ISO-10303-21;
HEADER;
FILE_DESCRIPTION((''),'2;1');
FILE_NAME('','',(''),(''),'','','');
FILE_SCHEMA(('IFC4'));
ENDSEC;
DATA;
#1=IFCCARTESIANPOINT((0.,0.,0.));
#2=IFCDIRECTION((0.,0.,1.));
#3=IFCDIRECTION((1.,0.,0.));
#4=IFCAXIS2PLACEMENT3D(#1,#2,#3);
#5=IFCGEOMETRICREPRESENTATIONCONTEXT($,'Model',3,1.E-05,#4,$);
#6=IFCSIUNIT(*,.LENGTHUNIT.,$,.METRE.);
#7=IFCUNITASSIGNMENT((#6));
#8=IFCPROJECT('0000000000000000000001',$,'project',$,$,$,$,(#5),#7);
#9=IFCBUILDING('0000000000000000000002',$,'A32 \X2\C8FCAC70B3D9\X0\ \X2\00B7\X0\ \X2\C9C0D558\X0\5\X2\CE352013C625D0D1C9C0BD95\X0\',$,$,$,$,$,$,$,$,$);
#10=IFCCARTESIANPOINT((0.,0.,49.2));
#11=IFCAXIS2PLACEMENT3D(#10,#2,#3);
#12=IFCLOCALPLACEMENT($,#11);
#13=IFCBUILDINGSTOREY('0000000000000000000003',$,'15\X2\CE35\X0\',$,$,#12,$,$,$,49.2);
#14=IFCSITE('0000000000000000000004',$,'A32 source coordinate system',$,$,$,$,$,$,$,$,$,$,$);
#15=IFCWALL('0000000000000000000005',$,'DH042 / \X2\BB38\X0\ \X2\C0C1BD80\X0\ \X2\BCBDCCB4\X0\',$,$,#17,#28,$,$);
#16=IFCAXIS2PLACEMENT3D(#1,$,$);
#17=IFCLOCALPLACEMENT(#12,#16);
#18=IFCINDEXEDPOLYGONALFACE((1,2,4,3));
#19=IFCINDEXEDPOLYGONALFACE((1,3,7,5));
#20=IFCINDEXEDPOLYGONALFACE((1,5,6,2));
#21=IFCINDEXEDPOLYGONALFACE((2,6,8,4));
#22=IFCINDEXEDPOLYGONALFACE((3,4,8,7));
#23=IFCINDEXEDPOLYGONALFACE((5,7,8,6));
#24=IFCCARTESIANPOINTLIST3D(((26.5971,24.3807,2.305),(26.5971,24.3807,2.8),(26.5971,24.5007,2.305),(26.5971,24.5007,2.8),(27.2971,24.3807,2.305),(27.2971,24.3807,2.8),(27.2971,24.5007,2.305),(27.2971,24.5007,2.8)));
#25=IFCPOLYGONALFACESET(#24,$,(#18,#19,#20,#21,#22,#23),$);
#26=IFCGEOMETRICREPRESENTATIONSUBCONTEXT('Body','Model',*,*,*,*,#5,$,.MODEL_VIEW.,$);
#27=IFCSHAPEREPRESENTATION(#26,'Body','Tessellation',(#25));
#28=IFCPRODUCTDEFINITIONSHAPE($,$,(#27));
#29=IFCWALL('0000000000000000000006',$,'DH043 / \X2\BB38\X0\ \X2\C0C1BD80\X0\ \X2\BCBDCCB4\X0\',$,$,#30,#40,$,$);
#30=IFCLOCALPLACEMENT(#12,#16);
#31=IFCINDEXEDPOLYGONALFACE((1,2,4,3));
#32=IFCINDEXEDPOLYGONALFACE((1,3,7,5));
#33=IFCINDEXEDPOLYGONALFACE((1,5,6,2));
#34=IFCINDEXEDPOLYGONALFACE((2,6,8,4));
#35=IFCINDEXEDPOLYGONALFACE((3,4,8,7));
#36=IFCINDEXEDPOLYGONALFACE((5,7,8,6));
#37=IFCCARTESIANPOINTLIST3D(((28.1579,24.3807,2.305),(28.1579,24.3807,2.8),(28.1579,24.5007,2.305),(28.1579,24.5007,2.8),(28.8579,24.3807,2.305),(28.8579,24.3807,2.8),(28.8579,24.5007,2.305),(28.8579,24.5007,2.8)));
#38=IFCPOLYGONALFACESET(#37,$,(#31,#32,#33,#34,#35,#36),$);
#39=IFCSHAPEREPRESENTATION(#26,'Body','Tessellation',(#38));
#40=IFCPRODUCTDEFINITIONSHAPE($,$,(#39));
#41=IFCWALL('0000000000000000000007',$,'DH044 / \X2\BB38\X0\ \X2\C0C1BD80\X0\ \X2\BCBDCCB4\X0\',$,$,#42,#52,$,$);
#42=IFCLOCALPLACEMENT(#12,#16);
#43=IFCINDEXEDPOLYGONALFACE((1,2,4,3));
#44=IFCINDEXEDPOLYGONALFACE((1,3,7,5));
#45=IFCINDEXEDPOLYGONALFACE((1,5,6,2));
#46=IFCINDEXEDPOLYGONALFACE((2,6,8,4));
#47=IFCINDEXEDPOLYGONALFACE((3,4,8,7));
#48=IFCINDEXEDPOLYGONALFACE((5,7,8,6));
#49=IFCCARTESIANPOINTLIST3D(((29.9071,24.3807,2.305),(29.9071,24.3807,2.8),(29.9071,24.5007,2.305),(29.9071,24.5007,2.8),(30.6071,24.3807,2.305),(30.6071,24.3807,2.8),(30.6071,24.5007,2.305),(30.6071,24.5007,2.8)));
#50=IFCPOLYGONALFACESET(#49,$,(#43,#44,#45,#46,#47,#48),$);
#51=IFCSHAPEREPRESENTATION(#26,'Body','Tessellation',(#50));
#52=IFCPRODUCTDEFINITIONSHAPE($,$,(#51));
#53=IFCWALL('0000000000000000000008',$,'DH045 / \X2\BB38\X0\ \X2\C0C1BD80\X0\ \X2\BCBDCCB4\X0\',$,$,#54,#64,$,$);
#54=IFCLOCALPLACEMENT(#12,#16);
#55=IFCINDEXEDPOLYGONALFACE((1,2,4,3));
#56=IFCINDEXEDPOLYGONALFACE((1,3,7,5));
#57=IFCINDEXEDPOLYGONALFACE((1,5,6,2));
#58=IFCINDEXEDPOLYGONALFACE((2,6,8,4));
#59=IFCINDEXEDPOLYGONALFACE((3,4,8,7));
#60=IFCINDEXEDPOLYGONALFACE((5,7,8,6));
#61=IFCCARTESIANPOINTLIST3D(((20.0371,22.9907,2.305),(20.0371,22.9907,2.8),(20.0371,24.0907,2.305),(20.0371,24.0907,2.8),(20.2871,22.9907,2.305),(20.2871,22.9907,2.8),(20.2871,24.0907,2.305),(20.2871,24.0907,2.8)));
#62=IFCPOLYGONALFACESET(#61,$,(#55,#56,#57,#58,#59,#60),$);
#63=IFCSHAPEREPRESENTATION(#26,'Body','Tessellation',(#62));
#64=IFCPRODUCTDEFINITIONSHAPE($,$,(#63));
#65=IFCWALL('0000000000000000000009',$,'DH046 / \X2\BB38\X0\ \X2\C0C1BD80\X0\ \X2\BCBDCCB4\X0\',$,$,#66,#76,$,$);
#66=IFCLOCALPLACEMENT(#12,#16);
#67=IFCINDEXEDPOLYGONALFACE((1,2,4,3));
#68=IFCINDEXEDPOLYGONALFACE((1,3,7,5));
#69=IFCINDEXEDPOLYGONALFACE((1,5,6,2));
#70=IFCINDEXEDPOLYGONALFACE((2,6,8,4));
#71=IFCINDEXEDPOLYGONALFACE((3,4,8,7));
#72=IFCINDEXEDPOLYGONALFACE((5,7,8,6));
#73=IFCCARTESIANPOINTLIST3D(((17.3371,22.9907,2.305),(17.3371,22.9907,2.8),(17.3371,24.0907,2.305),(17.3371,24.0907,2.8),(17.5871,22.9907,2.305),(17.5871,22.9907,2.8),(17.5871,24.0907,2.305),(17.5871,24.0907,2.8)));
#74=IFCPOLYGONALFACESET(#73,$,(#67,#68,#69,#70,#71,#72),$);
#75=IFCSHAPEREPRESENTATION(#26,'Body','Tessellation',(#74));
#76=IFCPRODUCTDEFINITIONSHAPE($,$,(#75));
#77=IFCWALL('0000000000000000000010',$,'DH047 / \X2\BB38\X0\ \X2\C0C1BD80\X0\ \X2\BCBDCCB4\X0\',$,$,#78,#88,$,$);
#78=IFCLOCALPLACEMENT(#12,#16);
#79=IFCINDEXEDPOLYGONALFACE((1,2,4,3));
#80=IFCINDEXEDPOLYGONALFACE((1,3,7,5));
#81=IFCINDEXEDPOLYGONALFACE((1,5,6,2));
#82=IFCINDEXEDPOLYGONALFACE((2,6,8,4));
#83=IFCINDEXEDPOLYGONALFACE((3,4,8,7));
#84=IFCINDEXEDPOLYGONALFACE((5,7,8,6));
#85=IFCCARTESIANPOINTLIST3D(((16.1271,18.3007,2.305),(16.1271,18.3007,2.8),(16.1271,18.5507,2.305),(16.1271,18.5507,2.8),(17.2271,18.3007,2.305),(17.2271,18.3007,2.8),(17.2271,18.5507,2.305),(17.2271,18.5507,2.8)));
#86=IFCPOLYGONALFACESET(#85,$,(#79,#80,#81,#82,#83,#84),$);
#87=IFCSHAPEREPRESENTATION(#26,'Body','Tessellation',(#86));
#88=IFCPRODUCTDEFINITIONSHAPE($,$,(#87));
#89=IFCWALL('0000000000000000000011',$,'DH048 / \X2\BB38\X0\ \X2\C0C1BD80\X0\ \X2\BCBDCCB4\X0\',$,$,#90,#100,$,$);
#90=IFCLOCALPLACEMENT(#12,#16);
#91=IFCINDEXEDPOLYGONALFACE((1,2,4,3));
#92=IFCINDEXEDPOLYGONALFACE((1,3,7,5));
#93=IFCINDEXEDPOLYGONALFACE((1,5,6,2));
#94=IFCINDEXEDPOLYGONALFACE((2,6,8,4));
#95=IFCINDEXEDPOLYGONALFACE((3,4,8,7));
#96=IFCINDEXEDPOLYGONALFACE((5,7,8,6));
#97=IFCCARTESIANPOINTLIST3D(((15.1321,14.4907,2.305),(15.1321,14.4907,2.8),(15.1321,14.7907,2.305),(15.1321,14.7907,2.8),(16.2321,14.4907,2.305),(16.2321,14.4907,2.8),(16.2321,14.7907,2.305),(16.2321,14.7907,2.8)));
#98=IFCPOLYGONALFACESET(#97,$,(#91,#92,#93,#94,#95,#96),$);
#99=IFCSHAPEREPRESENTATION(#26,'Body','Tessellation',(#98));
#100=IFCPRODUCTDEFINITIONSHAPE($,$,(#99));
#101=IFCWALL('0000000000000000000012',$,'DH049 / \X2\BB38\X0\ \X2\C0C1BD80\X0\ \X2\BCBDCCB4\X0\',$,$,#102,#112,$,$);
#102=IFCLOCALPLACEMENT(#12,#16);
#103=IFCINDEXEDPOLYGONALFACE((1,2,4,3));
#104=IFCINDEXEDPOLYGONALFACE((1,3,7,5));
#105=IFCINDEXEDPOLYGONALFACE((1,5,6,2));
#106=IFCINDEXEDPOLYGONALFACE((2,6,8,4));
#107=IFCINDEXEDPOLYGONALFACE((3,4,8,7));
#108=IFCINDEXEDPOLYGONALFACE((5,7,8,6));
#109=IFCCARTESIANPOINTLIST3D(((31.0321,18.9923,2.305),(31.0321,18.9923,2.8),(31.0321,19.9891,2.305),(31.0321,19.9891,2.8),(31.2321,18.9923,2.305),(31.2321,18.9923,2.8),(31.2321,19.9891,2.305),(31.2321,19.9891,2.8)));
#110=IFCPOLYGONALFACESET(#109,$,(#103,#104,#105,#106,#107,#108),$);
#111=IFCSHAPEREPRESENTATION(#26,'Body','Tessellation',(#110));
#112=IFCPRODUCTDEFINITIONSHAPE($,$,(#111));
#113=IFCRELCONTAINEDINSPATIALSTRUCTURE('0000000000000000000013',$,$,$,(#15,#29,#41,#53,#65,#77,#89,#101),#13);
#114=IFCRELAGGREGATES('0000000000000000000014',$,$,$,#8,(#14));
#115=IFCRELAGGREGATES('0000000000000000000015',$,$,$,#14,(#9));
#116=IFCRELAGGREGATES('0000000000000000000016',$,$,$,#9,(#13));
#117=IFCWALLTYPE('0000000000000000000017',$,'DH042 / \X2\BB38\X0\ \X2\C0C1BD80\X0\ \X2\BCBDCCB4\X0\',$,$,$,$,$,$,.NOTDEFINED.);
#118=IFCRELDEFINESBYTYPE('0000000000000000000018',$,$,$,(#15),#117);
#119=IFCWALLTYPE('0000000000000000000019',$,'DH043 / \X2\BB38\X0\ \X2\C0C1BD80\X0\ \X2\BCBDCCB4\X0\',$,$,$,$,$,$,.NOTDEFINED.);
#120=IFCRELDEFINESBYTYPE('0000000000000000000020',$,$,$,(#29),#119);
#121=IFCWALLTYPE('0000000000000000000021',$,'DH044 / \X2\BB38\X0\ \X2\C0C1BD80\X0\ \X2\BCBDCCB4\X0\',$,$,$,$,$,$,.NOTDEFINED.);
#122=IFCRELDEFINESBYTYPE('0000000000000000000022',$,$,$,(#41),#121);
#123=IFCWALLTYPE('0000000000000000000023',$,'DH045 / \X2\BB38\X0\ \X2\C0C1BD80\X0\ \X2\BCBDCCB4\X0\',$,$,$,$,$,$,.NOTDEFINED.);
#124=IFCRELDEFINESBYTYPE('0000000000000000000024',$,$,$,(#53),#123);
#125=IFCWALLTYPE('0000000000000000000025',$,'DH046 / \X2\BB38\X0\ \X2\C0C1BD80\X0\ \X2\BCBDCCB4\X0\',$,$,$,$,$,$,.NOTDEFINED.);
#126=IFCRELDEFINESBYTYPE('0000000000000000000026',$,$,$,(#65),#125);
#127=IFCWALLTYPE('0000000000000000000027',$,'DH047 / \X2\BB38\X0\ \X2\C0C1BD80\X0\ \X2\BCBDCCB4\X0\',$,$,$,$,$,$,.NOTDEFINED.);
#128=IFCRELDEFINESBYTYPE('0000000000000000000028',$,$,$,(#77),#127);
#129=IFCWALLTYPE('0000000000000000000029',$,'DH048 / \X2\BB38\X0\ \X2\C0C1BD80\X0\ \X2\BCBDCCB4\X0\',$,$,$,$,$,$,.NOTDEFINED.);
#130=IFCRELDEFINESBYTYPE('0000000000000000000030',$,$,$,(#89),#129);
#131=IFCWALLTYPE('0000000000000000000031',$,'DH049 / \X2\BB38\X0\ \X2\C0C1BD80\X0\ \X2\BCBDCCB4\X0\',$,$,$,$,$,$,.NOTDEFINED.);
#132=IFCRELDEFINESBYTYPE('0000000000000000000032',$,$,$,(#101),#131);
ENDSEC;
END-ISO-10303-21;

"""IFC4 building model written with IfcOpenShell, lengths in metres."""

from ifc_helpers import new_model, si_unit, frame, origin, origin_with_axes, place, context, subcontext, project, spatial, polyline, outline, extrude, source, transform, mapped, type_object, type_shapes, element, save


model = new_model("IFC4")

# Units and contexts
model_context = context("Model", 3, precision=1e-05, world=origin_with_axes())
body_context = subcontext(model_context, "Body", "Model", "MODEL_VIEW")
ifc_project = project(units=[si_unit("LENGTHUNIT", "METRE")], contexts=[model_context])

# Site, building, storey
site = spatial("IfcSite", under=ifc_project, Name="A32 source coordinate system")
building = spatial("IfcBuilding", under=site, Name="A32 주거동 · 지하5층–옥탑지붕")
storey_placement = place(None, frame((0.0, 0.0, 49.2), z_axis=(0.0, 0.0, 1.0), x_axis=(1.0, 0.0, 0.0)))
storey = spatial("IfcBuildingStorey", under=building, at=storey_placement, Name="15층", Elevation=49.2)

# Walls
wall_type_1 = type_object("IfcWallType", Name="DH042 / 문 상부 벽체", PredefinedType="NOTDEFINED")
shared_shape_1 = source(origin(), body_context, "Body", "SweptSolid", [
    extrude(outline(polyline([(27.2971, 24.3807), (26.5971, 24.3807), (26.5971, 24.5007), (27.2971, 24.5007), (27.2971, 24.3807)])), frame((0.0, 0.0, 2.305)), (0.0, 0.0, 1.0), 0.495),
])
type_shapes(wall_type_1, [shared_shape_1])
wall_1_placement = place(storey_placement, origin_with_axes())
element("IfcWall", 1, at=wall_1_placement, inside=storey, type_object=wall_type_1, Name="DH042 / 문 상부 벽체", context=body_context, shape_type="MappedRepresentation", body=[
    mapped(shared_shape_1, transform((0.0, 0.0, 0.0), scale=1.0)),
])
wall_type_2 = type_object("IfcWallType", Name="DH043 / 문 상부 벽체", PredefinedType="NOTDEFINED")
shared_shape_2 = source(origin(), body_context, "Body", "SweptSolid", [
    extrude(outline(polyline([(28.8579, 24.3807), (28.1579, 24.3807), (28.1579, 24.5007), (28.8579, 24.5007), (28.8579, 24.3807)])), frame((0.0, 0.0, 2.305)), (0.0, 0.0, 1.0), 0.495),
])
type_shapes(wall_type_2, [shared_shape_2])
wall_2_placement = place(storey_placement, origin_with_axes())
element("IfcWall", 2, at=wall_2_placement, inside=storey, type_object=wall_type_2, Name="DH043 / 문 상부 벽체", context=body_context, shape_type="MappedRepresentation", body=[
    mapped(shared_shape_2, transform((0.0, 0.0, 0.0), scale=1.0)),
])
wall_type_3 = type_object("IfcWallType", Name="DH044 / 문 상부 벽체", PredefinedType="NOTDEFINED")
shared_shape_3 = source(origin(), body_context, "Body", "SweptSolid", [
    extrude(outline(polyline([(30.6071, 24.3807), (29.9071, 24.3807), (29.9071, 24.5007), (30.6071, 24.5007), (30.6071, 24.3807)])), frame((0.0, 0.0, 2.305)), (0.0, 0.0, 1.0), 0.495),
])
type_shapes(wall_type_3, [shared_shape_3])
wall_3_placement = place(storey_placement, origin_with_axes())
element("IfcWall", 3, at=wall_3_placement, inside=storey, type_object=wall_type_3, Name="DH044 / 문 상부 벽체", context=body_context, shape_type="MappedRepresentation", body=[
    mapped(shared_shape_3, transform((0.0, 0.0, 0.0), scale=1.0)),
])
wall_type_4 = type_object("IfcWallType", Name="DH045 / 문 상부 벽체", PredefinedType="NOTDEFINED")
shared_shape_4 = source(origin(), body_context, "Body", "SweptSolid", [
    extrude(outline(polyline([(20.2871, 22.9907), (20.0371, 22.9907), (20.0371, 24.0907), (20.2871, 24.0907), (20.2871, 22.9907)])), frame((0.0, 0.0, 2.305)), (0.0, 0.0, 1.0), 0.495),
])
type_shapes(wall_type_4, [shared_shape_4])
wall_4_placement = place(storey_placement, origin_with_axes())
element("IfcWall", 4, at=wall_4_placement, inside=storey, type_object=wall_type_4, Name="DH045 / 문 상부 벽체", context=body_context, shape_type="MappedRepresentation", body=[
    mapped(shared_shape_4, transform((0.0, 0.0, 0.0), scale=1.0)),
])
wall_type_5 = type_object("IfcWallType", Name="DH046 / 문 상부 벽체", PredefinedType="NOTDEFINED")
shared_shape_5 = source(origin(), body_context, "Body", "SweptSolid", [
    extrude(outline(polyline([(17.5871, 22.9907), (17.3371, 22.9907), (17.3371, 24.0907), (17.5871, 24.0907), (17.5871, 22.9907)])), frame((0.0, 0.0, 2.305)), (0.0, 0.0, 1.0), 0.495),
])
type_shapes(wall_type_5, [shared_shape_5])
wall_5_placement = place(storey_placement, origin_with_axes())
element("IfcWall", 5, at=wall_5_placement, inside=storey, type_object=wall_type_5, Name="DH046 / 문 상부 벽체", context=body_context, shape_type="MappedRepresentation", body=[
    mapped(shared_shape_5, transform((0.0, 0.0, 0.0), scale=1.0)),
])
wall_type_6 = type_object("IfcWallType", Name="DH047 / 문 상부 벽체", PredefinedType="NOTDEFINED")
shared_shape_6 = source(origin(), body_context, "Body", "SweptSolid", [
    extrude(outline(polyline([(17.2271, 18.3007), (16.1271, 18.3007), (16.1271, 18.5507), (17.2271, 18.5507), (17.2271, 18.3007)])), frame((0.0, 0.0, 2.305)), (0.0, 0.0, 1.0), 0.495),
])
type_shapes(wall_type_6, [shared_shape_6])
wall_6_placement = place(storey_placement, origin_with_axes())
element("IfcWall", 6, at=wall_6_placement, inside=storey, type_object=wall_type_6, Name="DH047 / 문 상부 벽체", context=body_context, shape_type="MappedRepresentation", body=[
    mapped(shared_shape_6, transform((0.0, 0.0, 0.0), scale=1.0)),
])
wall_type_7 = type_object("IfcWallType", Name="DH048 / 문 상부 벽체", PredefinedType="NOTDEFINED")
shared_shape_7 = source(origin(), body_context, "Body", "SweptSolid", [
    extrude(outline(polyline([(15.1321, 14.7907), (16.2321, 14.7907), (16.2321, 14.4907), (15.1321, 14.4907), (15.1321, 14.7907)])), frame((0.0, 0.0, 2.305)), (0.0, 0.0, 1.0), 0.495),
])
type_shapes(wall_type_7, [shared_shape_7])
wall_7_placement = place(storey_placement, origin_with_axes())
element("IfcWall", 7, at=wall_7_placement, inside=storey, type_object=wall_type_7, Name="DH048 / 문 상부 벽체", context=body_context, shape_type="MappedRepresentation", body=[
    mapped(shared_shape_7, transform((0.0, 0.0, 0.0), scale=1.0)),
])
wall_type_8 = type_object("IfcWallType", Name="DH049 / 문 상부 벽체", PredefinedType="NOTDEFINED")
shared_shape_8 = source(origin(), body_context, "Body", "SweptSolid", [
    extrude(outline(polyline([(31.2321, 18.9923), (31.0321, 18.9923), (31.0321, 19.9891), (31.2321, 19.9891), (31.2321, 18.9923)])), frame((0.0, 0.0, 2.305)), (0.0, 0.0, 1.0), 0.495),
])
type_shapes(wall_type_8, [shared_shape_8])
wall_8_placement = place(storey_placement, origin_with_axes())
element("IfcWall", 8, at=wall_8_placement, inside=storey, type_object=wall_type_8, Name="DH049 / 문 상부 벽체", context=body_context, shape_type="MappedRepresentation", body=[
    mapped(shared_shape_8, transform((0.0, 0.0, 0.0), scale=1.0)),
])

save(model, "model.ifc")
